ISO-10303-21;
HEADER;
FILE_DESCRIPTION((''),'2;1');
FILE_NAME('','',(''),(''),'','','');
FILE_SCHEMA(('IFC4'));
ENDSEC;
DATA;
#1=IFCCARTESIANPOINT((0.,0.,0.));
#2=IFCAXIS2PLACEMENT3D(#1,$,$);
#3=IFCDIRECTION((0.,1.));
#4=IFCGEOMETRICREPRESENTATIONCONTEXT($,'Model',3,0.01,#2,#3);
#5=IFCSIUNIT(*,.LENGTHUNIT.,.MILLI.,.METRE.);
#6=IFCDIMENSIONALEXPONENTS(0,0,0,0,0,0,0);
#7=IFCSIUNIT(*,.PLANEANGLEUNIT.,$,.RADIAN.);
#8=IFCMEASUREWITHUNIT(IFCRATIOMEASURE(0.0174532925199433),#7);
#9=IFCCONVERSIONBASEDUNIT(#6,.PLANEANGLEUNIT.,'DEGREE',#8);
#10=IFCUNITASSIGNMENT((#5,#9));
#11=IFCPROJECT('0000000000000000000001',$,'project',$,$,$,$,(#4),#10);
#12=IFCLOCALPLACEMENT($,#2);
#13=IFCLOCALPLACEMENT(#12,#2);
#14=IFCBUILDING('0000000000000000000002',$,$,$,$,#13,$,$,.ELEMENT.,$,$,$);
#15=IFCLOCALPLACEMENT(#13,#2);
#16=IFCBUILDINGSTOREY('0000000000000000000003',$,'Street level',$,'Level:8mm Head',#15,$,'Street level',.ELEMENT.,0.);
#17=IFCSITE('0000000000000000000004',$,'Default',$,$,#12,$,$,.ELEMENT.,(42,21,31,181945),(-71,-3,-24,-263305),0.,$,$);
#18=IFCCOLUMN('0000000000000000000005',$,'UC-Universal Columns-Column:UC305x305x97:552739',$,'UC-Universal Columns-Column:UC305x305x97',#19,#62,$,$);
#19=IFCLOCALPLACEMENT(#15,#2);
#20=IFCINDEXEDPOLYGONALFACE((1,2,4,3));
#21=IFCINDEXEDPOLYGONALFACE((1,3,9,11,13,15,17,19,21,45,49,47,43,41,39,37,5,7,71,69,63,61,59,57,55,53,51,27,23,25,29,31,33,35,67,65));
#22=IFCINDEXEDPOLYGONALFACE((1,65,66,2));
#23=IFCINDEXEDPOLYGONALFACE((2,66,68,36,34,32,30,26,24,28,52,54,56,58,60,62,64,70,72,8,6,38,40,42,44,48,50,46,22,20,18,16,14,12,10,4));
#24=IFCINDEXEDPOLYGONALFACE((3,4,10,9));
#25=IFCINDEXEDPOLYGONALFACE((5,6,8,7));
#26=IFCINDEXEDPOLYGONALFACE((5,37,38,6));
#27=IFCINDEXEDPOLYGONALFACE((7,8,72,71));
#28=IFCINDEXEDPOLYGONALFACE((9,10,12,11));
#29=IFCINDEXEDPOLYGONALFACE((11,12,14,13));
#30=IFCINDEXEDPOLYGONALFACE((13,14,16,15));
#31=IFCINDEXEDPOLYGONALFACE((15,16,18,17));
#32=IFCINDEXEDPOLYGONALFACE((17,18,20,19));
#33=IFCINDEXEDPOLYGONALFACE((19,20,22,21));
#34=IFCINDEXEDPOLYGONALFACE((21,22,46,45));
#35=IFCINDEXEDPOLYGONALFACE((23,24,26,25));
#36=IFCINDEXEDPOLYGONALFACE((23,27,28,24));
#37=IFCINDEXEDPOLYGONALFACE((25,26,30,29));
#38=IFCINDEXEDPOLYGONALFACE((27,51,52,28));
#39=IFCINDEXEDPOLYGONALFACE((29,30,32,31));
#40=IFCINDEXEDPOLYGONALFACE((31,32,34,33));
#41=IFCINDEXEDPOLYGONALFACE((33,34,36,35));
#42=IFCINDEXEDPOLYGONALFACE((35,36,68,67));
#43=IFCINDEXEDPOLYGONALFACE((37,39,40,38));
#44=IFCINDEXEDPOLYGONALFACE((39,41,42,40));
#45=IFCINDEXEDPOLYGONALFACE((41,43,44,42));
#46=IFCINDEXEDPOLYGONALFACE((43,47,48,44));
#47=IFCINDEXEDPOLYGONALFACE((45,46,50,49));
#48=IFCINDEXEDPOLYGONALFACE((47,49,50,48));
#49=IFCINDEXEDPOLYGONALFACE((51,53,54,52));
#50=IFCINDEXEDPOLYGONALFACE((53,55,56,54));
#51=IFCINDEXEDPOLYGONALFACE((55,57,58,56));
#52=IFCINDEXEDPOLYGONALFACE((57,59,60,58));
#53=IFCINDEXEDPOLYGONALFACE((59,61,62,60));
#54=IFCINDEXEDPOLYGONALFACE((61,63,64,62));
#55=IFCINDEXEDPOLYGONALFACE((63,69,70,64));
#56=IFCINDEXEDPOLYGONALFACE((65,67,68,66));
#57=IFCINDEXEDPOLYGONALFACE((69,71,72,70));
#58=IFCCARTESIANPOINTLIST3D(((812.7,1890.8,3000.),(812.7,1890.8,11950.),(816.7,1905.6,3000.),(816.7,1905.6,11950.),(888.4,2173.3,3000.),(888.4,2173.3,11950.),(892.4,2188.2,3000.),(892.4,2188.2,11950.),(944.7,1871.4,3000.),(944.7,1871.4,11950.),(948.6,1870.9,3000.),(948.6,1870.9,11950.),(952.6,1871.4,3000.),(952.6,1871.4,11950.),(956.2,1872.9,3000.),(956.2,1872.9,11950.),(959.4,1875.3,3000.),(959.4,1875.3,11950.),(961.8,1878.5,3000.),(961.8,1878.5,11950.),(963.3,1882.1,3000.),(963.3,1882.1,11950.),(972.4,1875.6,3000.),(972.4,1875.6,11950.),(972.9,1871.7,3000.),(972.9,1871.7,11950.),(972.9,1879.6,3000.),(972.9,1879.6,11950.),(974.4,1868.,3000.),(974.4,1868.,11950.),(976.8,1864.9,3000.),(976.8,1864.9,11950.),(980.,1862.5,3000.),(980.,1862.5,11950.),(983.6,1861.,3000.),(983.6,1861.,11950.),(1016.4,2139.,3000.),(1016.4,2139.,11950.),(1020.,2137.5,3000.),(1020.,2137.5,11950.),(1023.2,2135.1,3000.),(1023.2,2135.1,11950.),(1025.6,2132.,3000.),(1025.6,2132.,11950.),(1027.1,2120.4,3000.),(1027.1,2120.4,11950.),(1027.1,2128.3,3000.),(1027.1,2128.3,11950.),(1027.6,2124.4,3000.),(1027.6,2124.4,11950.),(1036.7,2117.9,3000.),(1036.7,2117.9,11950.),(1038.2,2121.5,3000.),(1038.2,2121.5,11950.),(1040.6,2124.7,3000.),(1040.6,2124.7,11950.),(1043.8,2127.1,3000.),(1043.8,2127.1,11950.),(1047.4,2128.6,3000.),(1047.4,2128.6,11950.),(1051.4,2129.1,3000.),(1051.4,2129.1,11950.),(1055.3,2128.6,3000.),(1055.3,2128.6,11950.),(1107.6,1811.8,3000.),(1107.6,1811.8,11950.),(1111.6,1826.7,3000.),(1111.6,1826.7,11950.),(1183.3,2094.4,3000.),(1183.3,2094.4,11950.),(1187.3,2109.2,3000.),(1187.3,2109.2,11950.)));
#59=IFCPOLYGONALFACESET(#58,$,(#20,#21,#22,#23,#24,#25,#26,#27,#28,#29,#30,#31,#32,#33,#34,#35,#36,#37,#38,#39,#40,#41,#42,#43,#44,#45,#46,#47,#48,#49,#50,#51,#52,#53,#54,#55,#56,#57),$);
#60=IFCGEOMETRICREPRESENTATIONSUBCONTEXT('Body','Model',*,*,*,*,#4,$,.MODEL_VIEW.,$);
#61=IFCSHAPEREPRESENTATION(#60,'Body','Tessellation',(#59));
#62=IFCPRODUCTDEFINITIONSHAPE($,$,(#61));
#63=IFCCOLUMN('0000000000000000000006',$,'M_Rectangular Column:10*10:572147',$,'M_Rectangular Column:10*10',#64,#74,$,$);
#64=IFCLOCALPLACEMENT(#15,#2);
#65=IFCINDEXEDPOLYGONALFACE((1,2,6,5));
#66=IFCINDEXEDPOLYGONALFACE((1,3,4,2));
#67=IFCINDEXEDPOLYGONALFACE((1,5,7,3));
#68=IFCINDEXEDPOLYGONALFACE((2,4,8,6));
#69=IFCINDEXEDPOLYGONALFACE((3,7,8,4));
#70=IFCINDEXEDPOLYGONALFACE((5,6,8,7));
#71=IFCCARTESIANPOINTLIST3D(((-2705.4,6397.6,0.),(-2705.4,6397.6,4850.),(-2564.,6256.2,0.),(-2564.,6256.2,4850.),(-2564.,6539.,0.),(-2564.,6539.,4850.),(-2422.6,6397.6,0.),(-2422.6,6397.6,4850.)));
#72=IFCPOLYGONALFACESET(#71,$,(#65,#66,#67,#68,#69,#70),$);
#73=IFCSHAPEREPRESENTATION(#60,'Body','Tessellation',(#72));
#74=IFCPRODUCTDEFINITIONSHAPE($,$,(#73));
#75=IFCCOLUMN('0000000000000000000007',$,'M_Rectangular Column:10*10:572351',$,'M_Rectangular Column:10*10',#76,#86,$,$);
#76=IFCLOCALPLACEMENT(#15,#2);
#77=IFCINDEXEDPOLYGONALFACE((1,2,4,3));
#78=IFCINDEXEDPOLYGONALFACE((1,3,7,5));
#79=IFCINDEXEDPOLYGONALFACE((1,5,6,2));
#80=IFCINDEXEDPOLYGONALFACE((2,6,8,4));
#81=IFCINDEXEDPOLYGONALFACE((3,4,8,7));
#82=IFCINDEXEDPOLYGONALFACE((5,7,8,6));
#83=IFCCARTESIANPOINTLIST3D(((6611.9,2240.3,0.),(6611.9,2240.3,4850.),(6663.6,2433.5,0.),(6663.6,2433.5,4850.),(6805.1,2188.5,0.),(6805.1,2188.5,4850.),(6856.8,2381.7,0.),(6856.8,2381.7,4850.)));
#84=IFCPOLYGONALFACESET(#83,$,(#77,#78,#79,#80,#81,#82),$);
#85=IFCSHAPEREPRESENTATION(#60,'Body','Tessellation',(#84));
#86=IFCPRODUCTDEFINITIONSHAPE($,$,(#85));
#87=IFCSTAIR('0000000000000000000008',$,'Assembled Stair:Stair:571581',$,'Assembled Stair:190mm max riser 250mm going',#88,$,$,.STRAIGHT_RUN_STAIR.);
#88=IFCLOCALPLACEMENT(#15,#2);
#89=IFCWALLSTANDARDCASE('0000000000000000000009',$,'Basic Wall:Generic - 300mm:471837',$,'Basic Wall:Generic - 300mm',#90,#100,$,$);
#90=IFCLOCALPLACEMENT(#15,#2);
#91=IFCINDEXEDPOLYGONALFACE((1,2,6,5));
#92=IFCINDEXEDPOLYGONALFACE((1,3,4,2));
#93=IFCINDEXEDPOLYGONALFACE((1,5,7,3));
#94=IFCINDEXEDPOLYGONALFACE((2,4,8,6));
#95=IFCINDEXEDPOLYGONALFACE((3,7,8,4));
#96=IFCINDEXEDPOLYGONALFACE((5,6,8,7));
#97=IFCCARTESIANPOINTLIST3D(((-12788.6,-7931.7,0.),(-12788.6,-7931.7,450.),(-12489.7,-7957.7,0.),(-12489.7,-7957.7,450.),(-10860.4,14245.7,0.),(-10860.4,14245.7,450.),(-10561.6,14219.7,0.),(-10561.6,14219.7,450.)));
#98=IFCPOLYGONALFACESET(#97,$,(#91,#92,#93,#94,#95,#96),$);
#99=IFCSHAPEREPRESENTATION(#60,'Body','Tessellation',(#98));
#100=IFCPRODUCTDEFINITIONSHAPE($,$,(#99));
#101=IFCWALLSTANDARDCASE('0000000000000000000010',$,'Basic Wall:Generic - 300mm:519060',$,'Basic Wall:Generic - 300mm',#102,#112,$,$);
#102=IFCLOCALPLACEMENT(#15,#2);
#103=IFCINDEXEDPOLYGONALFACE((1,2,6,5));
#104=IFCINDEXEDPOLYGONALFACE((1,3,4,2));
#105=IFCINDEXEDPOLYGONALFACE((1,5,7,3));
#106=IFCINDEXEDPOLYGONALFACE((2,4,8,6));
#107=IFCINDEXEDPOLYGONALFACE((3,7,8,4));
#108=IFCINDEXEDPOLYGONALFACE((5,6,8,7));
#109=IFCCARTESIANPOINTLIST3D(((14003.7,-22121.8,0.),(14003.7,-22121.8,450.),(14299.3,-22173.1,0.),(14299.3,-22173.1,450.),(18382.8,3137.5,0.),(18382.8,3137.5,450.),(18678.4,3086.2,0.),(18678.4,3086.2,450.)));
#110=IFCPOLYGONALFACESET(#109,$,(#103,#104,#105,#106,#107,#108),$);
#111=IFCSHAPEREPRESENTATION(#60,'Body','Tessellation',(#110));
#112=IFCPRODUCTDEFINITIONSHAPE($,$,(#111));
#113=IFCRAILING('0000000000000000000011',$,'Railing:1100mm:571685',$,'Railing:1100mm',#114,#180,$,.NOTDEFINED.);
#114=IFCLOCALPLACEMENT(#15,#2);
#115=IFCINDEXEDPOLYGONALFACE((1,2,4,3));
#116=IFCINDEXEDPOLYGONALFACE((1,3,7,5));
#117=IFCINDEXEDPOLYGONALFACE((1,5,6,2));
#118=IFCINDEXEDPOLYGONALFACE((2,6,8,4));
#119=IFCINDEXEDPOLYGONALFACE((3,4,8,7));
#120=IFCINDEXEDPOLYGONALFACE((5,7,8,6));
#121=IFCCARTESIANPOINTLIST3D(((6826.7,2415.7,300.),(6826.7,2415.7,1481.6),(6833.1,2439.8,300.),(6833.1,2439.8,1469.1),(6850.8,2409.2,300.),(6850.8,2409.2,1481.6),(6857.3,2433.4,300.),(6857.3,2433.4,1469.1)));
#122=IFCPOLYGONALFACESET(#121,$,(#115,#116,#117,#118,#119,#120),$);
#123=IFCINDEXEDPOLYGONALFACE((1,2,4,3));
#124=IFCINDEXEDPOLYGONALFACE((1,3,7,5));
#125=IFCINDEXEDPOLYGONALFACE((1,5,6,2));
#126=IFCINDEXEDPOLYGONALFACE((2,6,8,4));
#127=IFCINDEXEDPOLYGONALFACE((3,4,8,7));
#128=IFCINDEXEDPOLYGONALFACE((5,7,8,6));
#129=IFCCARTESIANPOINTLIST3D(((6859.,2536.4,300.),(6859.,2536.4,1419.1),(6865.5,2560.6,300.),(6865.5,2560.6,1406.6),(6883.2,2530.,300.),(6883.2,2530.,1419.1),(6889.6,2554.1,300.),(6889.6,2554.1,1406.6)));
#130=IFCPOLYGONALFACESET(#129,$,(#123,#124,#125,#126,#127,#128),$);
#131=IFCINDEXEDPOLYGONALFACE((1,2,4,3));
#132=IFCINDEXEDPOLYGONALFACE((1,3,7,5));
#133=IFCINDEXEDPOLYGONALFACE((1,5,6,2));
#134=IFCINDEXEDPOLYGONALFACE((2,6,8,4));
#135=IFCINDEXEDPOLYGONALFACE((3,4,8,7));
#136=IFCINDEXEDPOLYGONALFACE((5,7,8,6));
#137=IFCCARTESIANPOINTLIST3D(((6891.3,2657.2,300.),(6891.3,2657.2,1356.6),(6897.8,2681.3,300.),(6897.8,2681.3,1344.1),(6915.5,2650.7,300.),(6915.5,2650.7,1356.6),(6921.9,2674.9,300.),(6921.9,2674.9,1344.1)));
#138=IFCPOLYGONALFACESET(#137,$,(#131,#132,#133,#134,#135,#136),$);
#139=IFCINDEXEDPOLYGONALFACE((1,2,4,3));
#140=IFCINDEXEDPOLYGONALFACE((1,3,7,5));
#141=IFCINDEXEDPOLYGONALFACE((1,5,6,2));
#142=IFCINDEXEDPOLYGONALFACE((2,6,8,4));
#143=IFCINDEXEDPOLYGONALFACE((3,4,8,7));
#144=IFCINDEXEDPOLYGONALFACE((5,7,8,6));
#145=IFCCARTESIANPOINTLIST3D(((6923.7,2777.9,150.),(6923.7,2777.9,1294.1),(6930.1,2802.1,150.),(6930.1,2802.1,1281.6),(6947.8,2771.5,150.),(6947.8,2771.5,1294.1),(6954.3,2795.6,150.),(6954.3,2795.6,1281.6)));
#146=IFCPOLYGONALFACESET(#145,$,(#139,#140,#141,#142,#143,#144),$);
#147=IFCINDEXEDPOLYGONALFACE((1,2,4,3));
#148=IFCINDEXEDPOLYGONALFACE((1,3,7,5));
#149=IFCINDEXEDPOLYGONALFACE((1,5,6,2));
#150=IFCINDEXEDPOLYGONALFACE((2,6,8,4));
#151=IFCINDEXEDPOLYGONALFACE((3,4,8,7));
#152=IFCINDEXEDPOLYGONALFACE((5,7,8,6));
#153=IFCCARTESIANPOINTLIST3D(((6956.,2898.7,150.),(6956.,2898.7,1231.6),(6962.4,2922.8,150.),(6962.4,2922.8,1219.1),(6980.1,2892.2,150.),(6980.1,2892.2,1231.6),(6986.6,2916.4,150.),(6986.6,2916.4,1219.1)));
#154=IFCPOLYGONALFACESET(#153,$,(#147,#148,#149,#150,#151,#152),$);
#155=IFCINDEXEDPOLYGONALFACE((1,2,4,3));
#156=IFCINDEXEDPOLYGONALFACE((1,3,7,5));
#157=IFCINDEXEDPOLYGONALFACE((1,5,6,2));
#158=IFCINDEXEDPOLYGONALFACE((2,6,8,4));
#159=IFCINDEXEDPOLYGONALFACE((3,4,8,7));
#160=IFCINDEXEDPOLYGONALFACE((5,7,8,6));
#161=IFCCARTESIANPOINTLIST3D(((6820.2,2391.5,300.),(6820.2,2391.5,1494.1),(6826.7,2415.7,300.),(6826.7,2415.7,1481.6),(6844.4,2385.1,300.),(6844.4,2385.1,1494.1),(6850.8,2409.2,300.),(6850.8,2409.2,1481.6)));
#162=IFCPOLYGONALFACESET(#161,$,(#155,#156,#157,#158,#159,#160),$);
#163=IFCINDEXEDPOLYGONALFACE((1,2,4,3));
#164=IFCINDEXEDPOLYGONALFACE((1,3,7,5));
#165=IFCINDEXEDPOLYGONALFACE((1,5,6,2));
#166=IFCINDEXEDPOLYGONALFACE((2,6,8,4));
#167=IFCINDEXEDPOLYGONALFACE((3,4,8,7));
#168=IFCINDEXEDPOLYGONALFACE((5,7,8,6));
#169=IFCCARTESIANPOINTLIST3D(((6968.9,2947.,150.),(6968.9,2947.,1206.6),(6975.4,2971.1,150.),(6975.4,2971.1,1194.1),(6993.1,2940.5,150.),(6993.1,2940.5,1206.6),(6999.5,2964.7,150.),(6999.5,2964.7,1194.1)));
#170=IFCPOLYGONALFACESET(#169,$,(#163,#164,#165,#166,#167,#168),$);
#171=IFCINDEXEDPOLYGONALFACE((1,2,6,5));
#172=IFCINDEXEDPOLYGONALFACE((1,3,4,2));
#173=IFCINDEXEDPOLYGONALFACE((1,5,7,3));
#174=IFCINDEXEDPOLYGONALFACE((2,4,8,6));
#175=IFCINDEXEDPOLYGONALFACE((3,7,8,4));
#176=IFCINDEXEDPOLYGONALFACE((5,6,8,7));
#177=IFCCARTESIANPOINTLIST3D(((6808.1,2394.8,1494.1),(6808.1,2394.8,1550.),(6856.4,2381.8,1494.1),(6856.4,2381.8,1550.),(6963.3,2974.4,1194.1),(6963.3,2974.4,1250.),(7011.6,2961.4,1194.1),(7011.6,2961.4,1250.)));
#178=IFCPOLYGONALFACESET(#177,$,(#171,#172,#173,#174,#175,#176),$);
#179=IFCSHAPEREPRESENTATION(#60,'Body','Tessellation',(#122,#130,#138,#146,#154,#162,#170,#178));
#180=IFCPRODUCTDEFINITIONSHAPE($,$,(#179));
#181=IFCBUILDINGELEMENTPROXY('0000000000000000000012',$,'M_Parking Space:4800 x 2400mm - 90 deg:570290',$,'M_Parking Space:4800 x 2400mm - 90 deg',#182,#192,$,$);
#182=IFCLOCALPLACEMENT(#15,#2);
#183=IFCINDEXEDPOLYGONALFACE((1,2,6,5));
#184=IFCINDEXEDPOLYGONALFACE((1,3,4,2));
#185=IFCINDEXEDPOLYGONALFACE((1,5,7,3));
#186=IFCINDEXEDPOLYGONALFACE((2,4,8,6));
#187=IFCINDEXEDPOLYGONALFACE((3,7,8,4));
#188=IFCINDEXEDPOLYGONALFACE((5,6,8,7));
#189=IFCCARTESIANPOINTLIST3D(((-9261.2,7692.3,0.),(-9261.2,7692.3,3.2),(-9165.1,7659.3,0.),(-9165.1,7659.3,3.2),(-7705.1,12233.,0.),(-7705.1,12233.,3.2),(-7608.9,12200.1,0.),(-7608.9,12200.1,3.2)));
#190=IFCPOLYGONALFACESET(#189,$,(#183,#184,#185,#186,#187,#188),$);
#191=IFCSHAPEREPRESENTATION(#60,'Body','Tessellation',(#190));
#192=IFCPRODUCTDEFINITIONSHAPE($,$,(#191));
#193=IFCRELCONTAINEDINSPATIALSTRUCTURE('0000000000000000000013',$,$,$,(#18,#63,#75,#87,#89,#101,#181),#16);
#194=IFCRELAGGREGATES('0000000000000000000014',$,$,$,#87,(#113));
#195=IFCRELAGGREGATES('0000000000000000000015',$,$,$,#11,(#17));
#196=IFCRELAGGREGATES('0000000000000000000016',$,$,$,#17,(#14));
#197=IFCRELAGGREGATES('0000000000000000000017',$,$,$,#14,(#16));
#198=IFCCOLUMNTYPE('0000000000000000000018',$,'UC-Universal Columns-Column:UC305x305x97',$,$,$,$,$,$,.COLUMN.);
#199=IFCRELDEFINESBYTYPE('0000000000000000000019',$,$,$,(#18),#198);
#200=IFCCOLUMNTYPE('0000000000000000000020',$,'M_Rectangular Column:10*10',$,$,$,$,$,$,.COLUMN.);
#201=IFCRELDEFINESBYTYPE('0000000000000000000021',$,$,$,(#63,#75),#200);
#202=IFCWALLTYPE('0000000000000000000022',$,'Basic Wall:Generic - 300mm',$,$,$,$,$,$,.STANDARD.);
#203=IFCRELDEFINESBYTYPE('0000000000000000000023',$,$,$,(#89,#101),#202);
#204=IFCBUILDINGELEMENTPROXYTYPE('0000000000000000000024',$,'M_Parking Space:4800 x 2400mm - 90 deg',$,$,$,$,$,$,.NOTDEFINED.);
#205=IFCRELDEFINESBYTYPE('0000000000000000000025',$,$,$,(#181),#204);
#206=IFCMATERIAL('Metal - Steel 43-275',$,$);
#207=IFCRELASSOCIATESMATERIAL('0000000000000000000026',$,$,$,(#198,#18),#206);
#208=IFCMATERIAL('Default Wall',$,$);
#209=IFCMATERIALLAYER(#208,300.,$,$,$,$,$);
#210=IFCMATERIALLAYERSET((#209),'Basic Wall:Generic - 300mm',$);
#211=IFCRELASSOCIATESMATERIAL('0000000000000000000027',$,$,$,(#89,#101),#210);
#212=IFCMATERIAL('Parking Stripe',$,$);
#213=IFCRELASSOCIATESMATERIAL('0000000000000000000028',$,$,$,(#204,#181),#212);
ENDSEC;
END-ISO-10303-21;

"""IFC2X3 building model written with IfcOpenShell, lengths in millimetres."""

from ifc_helpers import new_model, entity, si_unit, converted_unit, direction, frame, frame_2d, origin, origin_2d_with_axis, place, context, subcontext, project, spatial, polyline, rectangle, i_section, outline, extrude, source, transform, mapped, material, layer, layer_set, layer_usage, type_object, type_shapes, element, aggregate, save


model = new_model("IFC2X3")

# Units and contexts
model_context = context("Model", 3, precision=0.01, world=origin(), true_north=direction((0.0, 1.0)))
body_context = subcontext(model_context, "Body", "Model", "MODEL_VIEW")
ifc_project = project(units=[si_unit("LENGTHUNIT", "METRE", prefix="MILLI"), converted_unit("PLANEANGLEUNIT", "DEGREE", entity("IfcRatioMeasure", 0.0174532925199433), si_unit("PLANEANGLEUNIT", "RADIAN"), dimensions=[0, 0, 0, 0, 0, 0, 0])], contexts=[model_context])

# Site, building, storey
site_placement = place(None, origin())
site = spatial("IfcSite", under=ifc_project, at=site_placement, Name="Default", CompositionType="ELEMENT", RefLatitude=(42, 21, 31, 181945), RefLongitude=(-71, -3, -24, -263305), RefElevation=0.0)
building_placement = place(site_placement, origin())
building = spatial("IfcBuilding", under=site, at=building_placement, CompositionType="ELEMENT")
storey_placement = place(building_placement, origin())
storey = spatial("IfcBuildingStorey", under=building, at=storey_placement, Name="Street level", ObjectType="Level:8mm Head", LongName="Street level", CompositionType="ELEMENT", Elevation=0.0)

# Columns
ifc_material_1 = material(Name="Metal - Steel 43-275")
column_type_1 = type_object("IfcColumnType", Name="UC-Universal Columns-Column:UC305x305x97", PredefinedType="COLUMN", material=ifc_material_1)
shared_shape_1 = source(origin(), body_context, "Body", "SweptSolid", [
    extrude(i_section(OverallWidth=305.3, OverallDepth=307.9, WebThickness=9.9, FlangeThickness=15.4, FilletRadius=15.2, at=frame_2d((0.0, 0.0), x_axis=(0.0, 1.0))), frame((0.0, 0.0, 0.0), z_axis=(0.0, 0.0, 1.0), x_axis=(0.0, -1.0, 0.0)), (0.0, 0.0, 1.0), 8950.0),
])
type_shapes(column_type_1, [shared_shape_1])
column_placement = place(storey_placement, frame((1000.0, 2000.0, 3000.0), z_axis=(0.0, 0.0, 1.0), x_axis=(0.965983, -0.258607, 0.0)))
element("IfcColumn", 1, at=column_placement, inside=storey, type_object=column_type_1, material=ifc_material_1, Name="UC-Universal Columns-Column:UC305x305x97:552739", ObjectType="UC-Universal Columns-Column:UC305x305x97", context=body_context, shape_type="MappedRepresentation", body=[
    mapped(shared_shape_1, transform((0.0, 0.0, 0.0), scale=1.0)),
])
column_type_2 = type_object("IfcColumnType", Name="M_Rectangular Column:10*10", PredefinedType="COLUMN")
shared_shape_2 = source(origin(), body_context, "Body", "SweptSolid", [
    extrude(rectangle(XDim=200.0, YDim=200.0, at=origin_2d_with_axis()), frame((0.0, 0.0, 0.0), z_axis=(0.0, 0.0, 1.0), x_axis=(0.0, -1.0, 0.0)), (0.0, 0.0, 1.0), 4850.0),
])
type_shapes(column_type_2, [shared_shape_2])
for number, where, z_axis, x_axis, name in (
    (2, (-2564.0, 6397.6, 0.0), (0.0, 0.0, 1.0), (0.707107, 0.707107, 0.0), "M_Rectangular Column:10*10:572147"),
    (3, (6734.4, 2311.0, 0.0), (0.0, 0.0, 1.0), (0.258607, 0.965983, 0.0), "M_Rectangular Column:10*10:572351"),
):
    element("IfcColumn", number, at=place(storey_placement, frame(where, z_axis=z_axis, x_axis=x_axis)), inside=storey, type_object=column_type_2, Name=name, ObjectType="M_Rectangular Column:10*10", context=body_context, shape_type="MappedRepresentation", body=[
        mapped(shared_shape_2, transform((0.0, 0.0, 0.0), scale=1.0)),
    ])

# Stair
stair_placement = place(storey_placement, origin())
stair = element("IfcStair", 4, at=stair_placement, inside=storey, Name="Assembled Stair:Stair:571581", ObjectType="Assembled Stair:190mm max riser 250mm going", ShapeType="STRAIGHT_RUN_STAIR")

# Walls
ifc_material_2 = material(Name="Default Wall")
ifc_layer_1 = layer(ifc_material_2, 300.0)
ifc_layer_set_1 = layer_set([ifc_layer_1], Name="Basic Wall:Generic - 300mm")
ifc_layer_usage_1 = layer_usage(ifc_layer_set_1, "AXIS2", "NEGATIVE", 150.0)
wall_type = type_object("IfcWallType", Name="Basic Wall:Generic - 300mm", PredefinedType="STANDARD")
wall_1_placement = place(storey_placement, frame((-10711.0, 14232.7, 0.0), z_axis=(0.0, 0.0, 1.0), x_axis=(-0.086615, -0.996242, 0.0)))
element("IfcWallStandardCase", 5, at=wall_1_placement, inside=storey, type_object=wall_type, material=ifc_layer_usage_1, Name="Basic Wall:Generic - 300mm:471837", ObjectType="Basic Wall:Generic - 300mm", context=body_context, shape_type="SweptSolid", body=[
    extrude(rectangle(XDim=22261.1, YDim=300.0, at=frame_2d((11130.5, 0.0), x_axis=(-1.0, 0.0))), origin(), (0.0, 0.0, 1.0), 450.0),
])
ifc_layer_usage_2 = layer_usage(ifc_layer_set_1, "AXIS2", "NEGATIVE", 150.0)
wall_2_placement = place(storey_placement, frame((14151.5, -22147.4, 0.0), z_axis=(0.0, 0.0, 1.0), x_axis=(0.17082, 0.985302, 0.0)))
element("IfcWallStandardCase", 6, at=wall_2_placement, inside=storey, type_object=wall_type, material=ifc_layer_usage_2, Name="Basic Wall:Generic - 300mm:519060", ObjectType="Basic Wall:Generic - 300mm", context=body_context, shape_type="SweptSolid", body=[
    extrude(rectangle(XDim=25636.1, YDim=300.0, at=frame_2d((12818.0, 0.0), x_axis=(-1.0, 0.0))), origin(), (0.0, 0.0, 1.0), 450.0),
])

# Railing
railing_placement = place(stair_placement, origin())
railing = element("IfcRailing", 7, at=railing_placement, Name="Railing:1100mm:571685", ObjectType="Railing:1100mm", PredefinedType="NOTDEFINED", context=body_context, shape_type="SweptSolid", body=[
    extrude(outline(polyline([(-587.7, -12.5), (581.4, -12.5), (593.9, 12.5), (-587.7, 12.5), (-587.7, -12.5)])), frame((6829.9, 2427.8, 887.7), z_axis=(0.965983, -0.258606, 0.0), x_axis=(0.0, 0.0, 1.0)), (0.0, 0.0, 1.0), 25.0),
    extrude(outline(polyline([(-556.4, -12.5), (550.2, -12.5), (562.7, 12.5), (-556.4, 12.5), (-556.4, -12.5)])), frame((6862.2, 2548.5, 856.4), z_axis=(0.965983, -0.258606, 0.0), x_axis=(0.0, 0.0, 1.0)), (0.0, 0.0, 1.0), 25.0),
    extrude(outline(polyline([(-525.2, -12.5), (518.9, -12.5), (531.4, 12.5), (-525.2, 12.5), (-525.2, -12.5)])), frame((6894.6, 2669.3, 825.2), z_axis=(0.965983, -0.258606, 0.0), x_axis=(0.0, 0.0, 1.0)), (0.0, 0.0, 1.0), 25.0),
    extrude(outline(polyline([(-568.9, -12.5), (562.7, -12.5), (575.2, 12.5), (-568.9, 12.5), (-568.9, -12.5)])), frame((6926.9, 2790.0, 718.9), z_axis=(0.965983, -0.258606, 0.0), x_axis=(0.0, 0.0, 1.0)), (0.0, 0.0, 1.0), 25.0),
    extrude(outline(polyline([(-537.7, -12.5), (531.4, -12.5), (543.9, 12.5), (-537.7, 12.5), (-537.7, -12.5)])), frame((6959.2, 2910.8, 687.7), z_axis=(0.965983, -0.258606, 0.0), x_axis=(0.0, 0.0, 1.0)), (0.0, 0.0, 1.0), 25.0),
    extrude(outline(polyline([(-593.9, -12.5), (587.7, -12.5), (600.2, 12.5), (-593.9, 12.5), (-593.9, -12.5)])), frame((6823.4, 2403.6, 893.9), z_axis=(0.965983, -0.258606, 0.0), x_axis=(0.0, 0.0, 1.0)), (0.0, 0.0, 1.0), 25.0),
    extrude(outline(polyline([(-525.2, -12.5), (518.9, -12.5), (531.4, 12.5), (-525.2, 12.5), (-525.2, -12.5)])), frame((6972.1, 2959.1, 675.2), z_axis=(0.965983, -0.258606, 0.0), x_axis=(0.0, 0.0, 1.0)), (0.0, 0.0, 1.0), 25.0),
    extrude(outline(polyline([(-322.9, -25.0), (347.9, -25.0), (322.9, 25.0), (-347.9, 25.0), (-322.9, -25.0)])), frame((6885.7, 2684.6, 1372.0), z_axis=(0.965983, -0.258606, 0.0), x_axis=(-0.231304, -0.864001, 0.447214)), (0.0, 0.0, 1.0), 50.0),
])
aggregate(stair, [railing])

# Building element proxy
ifc_material_3 = material(Name="Parking Stripe")
building_element_proxy_type = type_object("IfcBuildingElementProxyType", Name="M_Parking Space:4800 x 2400mm - 90 deg", PredefinedType="NOTDEFINED", material=ifc_material_3)
shared_shape_3 = source(origin(), body_context, "Body", "SweptSolid", [
    extrude(rectangle(XDim=101.6, YDim=4800.0, at=origin_2d_with_axis()), frame((0.0, 2400.0, 0.0)), (0.0, 0.0, 1.0), 3.2),
])
type_shapes(building_element_proxy_type, [shared_shape_3])
for number, where, z_axis, x_axis, name in (
    (8, (-9213.1, 7675.8, 0.0), (0.0, 0.0, 1.0), (0.945989, -0.324198, 0.0), "M_Parking Space:4800 x 2400mm - 90 deg:570290"),
):
    element("IfcBuildingElementProxy", number, at=place(storey_placement, frame(where, z_axis=z_axis, x_axis=x_axis)), inside=storey, type_object=building_element_proxy_type, material=ifc_material_3, Name=name, ObjectType="M_Parking Space:4800 x 2400mm - 90 deg", context=body_context, shape_type="MappedRepresentation", body=[
        mapped(shared_shape_3, transform((0.0, 0.0, 0.0), scale=1.0)),
    ])

save(model, "model.ifc")
